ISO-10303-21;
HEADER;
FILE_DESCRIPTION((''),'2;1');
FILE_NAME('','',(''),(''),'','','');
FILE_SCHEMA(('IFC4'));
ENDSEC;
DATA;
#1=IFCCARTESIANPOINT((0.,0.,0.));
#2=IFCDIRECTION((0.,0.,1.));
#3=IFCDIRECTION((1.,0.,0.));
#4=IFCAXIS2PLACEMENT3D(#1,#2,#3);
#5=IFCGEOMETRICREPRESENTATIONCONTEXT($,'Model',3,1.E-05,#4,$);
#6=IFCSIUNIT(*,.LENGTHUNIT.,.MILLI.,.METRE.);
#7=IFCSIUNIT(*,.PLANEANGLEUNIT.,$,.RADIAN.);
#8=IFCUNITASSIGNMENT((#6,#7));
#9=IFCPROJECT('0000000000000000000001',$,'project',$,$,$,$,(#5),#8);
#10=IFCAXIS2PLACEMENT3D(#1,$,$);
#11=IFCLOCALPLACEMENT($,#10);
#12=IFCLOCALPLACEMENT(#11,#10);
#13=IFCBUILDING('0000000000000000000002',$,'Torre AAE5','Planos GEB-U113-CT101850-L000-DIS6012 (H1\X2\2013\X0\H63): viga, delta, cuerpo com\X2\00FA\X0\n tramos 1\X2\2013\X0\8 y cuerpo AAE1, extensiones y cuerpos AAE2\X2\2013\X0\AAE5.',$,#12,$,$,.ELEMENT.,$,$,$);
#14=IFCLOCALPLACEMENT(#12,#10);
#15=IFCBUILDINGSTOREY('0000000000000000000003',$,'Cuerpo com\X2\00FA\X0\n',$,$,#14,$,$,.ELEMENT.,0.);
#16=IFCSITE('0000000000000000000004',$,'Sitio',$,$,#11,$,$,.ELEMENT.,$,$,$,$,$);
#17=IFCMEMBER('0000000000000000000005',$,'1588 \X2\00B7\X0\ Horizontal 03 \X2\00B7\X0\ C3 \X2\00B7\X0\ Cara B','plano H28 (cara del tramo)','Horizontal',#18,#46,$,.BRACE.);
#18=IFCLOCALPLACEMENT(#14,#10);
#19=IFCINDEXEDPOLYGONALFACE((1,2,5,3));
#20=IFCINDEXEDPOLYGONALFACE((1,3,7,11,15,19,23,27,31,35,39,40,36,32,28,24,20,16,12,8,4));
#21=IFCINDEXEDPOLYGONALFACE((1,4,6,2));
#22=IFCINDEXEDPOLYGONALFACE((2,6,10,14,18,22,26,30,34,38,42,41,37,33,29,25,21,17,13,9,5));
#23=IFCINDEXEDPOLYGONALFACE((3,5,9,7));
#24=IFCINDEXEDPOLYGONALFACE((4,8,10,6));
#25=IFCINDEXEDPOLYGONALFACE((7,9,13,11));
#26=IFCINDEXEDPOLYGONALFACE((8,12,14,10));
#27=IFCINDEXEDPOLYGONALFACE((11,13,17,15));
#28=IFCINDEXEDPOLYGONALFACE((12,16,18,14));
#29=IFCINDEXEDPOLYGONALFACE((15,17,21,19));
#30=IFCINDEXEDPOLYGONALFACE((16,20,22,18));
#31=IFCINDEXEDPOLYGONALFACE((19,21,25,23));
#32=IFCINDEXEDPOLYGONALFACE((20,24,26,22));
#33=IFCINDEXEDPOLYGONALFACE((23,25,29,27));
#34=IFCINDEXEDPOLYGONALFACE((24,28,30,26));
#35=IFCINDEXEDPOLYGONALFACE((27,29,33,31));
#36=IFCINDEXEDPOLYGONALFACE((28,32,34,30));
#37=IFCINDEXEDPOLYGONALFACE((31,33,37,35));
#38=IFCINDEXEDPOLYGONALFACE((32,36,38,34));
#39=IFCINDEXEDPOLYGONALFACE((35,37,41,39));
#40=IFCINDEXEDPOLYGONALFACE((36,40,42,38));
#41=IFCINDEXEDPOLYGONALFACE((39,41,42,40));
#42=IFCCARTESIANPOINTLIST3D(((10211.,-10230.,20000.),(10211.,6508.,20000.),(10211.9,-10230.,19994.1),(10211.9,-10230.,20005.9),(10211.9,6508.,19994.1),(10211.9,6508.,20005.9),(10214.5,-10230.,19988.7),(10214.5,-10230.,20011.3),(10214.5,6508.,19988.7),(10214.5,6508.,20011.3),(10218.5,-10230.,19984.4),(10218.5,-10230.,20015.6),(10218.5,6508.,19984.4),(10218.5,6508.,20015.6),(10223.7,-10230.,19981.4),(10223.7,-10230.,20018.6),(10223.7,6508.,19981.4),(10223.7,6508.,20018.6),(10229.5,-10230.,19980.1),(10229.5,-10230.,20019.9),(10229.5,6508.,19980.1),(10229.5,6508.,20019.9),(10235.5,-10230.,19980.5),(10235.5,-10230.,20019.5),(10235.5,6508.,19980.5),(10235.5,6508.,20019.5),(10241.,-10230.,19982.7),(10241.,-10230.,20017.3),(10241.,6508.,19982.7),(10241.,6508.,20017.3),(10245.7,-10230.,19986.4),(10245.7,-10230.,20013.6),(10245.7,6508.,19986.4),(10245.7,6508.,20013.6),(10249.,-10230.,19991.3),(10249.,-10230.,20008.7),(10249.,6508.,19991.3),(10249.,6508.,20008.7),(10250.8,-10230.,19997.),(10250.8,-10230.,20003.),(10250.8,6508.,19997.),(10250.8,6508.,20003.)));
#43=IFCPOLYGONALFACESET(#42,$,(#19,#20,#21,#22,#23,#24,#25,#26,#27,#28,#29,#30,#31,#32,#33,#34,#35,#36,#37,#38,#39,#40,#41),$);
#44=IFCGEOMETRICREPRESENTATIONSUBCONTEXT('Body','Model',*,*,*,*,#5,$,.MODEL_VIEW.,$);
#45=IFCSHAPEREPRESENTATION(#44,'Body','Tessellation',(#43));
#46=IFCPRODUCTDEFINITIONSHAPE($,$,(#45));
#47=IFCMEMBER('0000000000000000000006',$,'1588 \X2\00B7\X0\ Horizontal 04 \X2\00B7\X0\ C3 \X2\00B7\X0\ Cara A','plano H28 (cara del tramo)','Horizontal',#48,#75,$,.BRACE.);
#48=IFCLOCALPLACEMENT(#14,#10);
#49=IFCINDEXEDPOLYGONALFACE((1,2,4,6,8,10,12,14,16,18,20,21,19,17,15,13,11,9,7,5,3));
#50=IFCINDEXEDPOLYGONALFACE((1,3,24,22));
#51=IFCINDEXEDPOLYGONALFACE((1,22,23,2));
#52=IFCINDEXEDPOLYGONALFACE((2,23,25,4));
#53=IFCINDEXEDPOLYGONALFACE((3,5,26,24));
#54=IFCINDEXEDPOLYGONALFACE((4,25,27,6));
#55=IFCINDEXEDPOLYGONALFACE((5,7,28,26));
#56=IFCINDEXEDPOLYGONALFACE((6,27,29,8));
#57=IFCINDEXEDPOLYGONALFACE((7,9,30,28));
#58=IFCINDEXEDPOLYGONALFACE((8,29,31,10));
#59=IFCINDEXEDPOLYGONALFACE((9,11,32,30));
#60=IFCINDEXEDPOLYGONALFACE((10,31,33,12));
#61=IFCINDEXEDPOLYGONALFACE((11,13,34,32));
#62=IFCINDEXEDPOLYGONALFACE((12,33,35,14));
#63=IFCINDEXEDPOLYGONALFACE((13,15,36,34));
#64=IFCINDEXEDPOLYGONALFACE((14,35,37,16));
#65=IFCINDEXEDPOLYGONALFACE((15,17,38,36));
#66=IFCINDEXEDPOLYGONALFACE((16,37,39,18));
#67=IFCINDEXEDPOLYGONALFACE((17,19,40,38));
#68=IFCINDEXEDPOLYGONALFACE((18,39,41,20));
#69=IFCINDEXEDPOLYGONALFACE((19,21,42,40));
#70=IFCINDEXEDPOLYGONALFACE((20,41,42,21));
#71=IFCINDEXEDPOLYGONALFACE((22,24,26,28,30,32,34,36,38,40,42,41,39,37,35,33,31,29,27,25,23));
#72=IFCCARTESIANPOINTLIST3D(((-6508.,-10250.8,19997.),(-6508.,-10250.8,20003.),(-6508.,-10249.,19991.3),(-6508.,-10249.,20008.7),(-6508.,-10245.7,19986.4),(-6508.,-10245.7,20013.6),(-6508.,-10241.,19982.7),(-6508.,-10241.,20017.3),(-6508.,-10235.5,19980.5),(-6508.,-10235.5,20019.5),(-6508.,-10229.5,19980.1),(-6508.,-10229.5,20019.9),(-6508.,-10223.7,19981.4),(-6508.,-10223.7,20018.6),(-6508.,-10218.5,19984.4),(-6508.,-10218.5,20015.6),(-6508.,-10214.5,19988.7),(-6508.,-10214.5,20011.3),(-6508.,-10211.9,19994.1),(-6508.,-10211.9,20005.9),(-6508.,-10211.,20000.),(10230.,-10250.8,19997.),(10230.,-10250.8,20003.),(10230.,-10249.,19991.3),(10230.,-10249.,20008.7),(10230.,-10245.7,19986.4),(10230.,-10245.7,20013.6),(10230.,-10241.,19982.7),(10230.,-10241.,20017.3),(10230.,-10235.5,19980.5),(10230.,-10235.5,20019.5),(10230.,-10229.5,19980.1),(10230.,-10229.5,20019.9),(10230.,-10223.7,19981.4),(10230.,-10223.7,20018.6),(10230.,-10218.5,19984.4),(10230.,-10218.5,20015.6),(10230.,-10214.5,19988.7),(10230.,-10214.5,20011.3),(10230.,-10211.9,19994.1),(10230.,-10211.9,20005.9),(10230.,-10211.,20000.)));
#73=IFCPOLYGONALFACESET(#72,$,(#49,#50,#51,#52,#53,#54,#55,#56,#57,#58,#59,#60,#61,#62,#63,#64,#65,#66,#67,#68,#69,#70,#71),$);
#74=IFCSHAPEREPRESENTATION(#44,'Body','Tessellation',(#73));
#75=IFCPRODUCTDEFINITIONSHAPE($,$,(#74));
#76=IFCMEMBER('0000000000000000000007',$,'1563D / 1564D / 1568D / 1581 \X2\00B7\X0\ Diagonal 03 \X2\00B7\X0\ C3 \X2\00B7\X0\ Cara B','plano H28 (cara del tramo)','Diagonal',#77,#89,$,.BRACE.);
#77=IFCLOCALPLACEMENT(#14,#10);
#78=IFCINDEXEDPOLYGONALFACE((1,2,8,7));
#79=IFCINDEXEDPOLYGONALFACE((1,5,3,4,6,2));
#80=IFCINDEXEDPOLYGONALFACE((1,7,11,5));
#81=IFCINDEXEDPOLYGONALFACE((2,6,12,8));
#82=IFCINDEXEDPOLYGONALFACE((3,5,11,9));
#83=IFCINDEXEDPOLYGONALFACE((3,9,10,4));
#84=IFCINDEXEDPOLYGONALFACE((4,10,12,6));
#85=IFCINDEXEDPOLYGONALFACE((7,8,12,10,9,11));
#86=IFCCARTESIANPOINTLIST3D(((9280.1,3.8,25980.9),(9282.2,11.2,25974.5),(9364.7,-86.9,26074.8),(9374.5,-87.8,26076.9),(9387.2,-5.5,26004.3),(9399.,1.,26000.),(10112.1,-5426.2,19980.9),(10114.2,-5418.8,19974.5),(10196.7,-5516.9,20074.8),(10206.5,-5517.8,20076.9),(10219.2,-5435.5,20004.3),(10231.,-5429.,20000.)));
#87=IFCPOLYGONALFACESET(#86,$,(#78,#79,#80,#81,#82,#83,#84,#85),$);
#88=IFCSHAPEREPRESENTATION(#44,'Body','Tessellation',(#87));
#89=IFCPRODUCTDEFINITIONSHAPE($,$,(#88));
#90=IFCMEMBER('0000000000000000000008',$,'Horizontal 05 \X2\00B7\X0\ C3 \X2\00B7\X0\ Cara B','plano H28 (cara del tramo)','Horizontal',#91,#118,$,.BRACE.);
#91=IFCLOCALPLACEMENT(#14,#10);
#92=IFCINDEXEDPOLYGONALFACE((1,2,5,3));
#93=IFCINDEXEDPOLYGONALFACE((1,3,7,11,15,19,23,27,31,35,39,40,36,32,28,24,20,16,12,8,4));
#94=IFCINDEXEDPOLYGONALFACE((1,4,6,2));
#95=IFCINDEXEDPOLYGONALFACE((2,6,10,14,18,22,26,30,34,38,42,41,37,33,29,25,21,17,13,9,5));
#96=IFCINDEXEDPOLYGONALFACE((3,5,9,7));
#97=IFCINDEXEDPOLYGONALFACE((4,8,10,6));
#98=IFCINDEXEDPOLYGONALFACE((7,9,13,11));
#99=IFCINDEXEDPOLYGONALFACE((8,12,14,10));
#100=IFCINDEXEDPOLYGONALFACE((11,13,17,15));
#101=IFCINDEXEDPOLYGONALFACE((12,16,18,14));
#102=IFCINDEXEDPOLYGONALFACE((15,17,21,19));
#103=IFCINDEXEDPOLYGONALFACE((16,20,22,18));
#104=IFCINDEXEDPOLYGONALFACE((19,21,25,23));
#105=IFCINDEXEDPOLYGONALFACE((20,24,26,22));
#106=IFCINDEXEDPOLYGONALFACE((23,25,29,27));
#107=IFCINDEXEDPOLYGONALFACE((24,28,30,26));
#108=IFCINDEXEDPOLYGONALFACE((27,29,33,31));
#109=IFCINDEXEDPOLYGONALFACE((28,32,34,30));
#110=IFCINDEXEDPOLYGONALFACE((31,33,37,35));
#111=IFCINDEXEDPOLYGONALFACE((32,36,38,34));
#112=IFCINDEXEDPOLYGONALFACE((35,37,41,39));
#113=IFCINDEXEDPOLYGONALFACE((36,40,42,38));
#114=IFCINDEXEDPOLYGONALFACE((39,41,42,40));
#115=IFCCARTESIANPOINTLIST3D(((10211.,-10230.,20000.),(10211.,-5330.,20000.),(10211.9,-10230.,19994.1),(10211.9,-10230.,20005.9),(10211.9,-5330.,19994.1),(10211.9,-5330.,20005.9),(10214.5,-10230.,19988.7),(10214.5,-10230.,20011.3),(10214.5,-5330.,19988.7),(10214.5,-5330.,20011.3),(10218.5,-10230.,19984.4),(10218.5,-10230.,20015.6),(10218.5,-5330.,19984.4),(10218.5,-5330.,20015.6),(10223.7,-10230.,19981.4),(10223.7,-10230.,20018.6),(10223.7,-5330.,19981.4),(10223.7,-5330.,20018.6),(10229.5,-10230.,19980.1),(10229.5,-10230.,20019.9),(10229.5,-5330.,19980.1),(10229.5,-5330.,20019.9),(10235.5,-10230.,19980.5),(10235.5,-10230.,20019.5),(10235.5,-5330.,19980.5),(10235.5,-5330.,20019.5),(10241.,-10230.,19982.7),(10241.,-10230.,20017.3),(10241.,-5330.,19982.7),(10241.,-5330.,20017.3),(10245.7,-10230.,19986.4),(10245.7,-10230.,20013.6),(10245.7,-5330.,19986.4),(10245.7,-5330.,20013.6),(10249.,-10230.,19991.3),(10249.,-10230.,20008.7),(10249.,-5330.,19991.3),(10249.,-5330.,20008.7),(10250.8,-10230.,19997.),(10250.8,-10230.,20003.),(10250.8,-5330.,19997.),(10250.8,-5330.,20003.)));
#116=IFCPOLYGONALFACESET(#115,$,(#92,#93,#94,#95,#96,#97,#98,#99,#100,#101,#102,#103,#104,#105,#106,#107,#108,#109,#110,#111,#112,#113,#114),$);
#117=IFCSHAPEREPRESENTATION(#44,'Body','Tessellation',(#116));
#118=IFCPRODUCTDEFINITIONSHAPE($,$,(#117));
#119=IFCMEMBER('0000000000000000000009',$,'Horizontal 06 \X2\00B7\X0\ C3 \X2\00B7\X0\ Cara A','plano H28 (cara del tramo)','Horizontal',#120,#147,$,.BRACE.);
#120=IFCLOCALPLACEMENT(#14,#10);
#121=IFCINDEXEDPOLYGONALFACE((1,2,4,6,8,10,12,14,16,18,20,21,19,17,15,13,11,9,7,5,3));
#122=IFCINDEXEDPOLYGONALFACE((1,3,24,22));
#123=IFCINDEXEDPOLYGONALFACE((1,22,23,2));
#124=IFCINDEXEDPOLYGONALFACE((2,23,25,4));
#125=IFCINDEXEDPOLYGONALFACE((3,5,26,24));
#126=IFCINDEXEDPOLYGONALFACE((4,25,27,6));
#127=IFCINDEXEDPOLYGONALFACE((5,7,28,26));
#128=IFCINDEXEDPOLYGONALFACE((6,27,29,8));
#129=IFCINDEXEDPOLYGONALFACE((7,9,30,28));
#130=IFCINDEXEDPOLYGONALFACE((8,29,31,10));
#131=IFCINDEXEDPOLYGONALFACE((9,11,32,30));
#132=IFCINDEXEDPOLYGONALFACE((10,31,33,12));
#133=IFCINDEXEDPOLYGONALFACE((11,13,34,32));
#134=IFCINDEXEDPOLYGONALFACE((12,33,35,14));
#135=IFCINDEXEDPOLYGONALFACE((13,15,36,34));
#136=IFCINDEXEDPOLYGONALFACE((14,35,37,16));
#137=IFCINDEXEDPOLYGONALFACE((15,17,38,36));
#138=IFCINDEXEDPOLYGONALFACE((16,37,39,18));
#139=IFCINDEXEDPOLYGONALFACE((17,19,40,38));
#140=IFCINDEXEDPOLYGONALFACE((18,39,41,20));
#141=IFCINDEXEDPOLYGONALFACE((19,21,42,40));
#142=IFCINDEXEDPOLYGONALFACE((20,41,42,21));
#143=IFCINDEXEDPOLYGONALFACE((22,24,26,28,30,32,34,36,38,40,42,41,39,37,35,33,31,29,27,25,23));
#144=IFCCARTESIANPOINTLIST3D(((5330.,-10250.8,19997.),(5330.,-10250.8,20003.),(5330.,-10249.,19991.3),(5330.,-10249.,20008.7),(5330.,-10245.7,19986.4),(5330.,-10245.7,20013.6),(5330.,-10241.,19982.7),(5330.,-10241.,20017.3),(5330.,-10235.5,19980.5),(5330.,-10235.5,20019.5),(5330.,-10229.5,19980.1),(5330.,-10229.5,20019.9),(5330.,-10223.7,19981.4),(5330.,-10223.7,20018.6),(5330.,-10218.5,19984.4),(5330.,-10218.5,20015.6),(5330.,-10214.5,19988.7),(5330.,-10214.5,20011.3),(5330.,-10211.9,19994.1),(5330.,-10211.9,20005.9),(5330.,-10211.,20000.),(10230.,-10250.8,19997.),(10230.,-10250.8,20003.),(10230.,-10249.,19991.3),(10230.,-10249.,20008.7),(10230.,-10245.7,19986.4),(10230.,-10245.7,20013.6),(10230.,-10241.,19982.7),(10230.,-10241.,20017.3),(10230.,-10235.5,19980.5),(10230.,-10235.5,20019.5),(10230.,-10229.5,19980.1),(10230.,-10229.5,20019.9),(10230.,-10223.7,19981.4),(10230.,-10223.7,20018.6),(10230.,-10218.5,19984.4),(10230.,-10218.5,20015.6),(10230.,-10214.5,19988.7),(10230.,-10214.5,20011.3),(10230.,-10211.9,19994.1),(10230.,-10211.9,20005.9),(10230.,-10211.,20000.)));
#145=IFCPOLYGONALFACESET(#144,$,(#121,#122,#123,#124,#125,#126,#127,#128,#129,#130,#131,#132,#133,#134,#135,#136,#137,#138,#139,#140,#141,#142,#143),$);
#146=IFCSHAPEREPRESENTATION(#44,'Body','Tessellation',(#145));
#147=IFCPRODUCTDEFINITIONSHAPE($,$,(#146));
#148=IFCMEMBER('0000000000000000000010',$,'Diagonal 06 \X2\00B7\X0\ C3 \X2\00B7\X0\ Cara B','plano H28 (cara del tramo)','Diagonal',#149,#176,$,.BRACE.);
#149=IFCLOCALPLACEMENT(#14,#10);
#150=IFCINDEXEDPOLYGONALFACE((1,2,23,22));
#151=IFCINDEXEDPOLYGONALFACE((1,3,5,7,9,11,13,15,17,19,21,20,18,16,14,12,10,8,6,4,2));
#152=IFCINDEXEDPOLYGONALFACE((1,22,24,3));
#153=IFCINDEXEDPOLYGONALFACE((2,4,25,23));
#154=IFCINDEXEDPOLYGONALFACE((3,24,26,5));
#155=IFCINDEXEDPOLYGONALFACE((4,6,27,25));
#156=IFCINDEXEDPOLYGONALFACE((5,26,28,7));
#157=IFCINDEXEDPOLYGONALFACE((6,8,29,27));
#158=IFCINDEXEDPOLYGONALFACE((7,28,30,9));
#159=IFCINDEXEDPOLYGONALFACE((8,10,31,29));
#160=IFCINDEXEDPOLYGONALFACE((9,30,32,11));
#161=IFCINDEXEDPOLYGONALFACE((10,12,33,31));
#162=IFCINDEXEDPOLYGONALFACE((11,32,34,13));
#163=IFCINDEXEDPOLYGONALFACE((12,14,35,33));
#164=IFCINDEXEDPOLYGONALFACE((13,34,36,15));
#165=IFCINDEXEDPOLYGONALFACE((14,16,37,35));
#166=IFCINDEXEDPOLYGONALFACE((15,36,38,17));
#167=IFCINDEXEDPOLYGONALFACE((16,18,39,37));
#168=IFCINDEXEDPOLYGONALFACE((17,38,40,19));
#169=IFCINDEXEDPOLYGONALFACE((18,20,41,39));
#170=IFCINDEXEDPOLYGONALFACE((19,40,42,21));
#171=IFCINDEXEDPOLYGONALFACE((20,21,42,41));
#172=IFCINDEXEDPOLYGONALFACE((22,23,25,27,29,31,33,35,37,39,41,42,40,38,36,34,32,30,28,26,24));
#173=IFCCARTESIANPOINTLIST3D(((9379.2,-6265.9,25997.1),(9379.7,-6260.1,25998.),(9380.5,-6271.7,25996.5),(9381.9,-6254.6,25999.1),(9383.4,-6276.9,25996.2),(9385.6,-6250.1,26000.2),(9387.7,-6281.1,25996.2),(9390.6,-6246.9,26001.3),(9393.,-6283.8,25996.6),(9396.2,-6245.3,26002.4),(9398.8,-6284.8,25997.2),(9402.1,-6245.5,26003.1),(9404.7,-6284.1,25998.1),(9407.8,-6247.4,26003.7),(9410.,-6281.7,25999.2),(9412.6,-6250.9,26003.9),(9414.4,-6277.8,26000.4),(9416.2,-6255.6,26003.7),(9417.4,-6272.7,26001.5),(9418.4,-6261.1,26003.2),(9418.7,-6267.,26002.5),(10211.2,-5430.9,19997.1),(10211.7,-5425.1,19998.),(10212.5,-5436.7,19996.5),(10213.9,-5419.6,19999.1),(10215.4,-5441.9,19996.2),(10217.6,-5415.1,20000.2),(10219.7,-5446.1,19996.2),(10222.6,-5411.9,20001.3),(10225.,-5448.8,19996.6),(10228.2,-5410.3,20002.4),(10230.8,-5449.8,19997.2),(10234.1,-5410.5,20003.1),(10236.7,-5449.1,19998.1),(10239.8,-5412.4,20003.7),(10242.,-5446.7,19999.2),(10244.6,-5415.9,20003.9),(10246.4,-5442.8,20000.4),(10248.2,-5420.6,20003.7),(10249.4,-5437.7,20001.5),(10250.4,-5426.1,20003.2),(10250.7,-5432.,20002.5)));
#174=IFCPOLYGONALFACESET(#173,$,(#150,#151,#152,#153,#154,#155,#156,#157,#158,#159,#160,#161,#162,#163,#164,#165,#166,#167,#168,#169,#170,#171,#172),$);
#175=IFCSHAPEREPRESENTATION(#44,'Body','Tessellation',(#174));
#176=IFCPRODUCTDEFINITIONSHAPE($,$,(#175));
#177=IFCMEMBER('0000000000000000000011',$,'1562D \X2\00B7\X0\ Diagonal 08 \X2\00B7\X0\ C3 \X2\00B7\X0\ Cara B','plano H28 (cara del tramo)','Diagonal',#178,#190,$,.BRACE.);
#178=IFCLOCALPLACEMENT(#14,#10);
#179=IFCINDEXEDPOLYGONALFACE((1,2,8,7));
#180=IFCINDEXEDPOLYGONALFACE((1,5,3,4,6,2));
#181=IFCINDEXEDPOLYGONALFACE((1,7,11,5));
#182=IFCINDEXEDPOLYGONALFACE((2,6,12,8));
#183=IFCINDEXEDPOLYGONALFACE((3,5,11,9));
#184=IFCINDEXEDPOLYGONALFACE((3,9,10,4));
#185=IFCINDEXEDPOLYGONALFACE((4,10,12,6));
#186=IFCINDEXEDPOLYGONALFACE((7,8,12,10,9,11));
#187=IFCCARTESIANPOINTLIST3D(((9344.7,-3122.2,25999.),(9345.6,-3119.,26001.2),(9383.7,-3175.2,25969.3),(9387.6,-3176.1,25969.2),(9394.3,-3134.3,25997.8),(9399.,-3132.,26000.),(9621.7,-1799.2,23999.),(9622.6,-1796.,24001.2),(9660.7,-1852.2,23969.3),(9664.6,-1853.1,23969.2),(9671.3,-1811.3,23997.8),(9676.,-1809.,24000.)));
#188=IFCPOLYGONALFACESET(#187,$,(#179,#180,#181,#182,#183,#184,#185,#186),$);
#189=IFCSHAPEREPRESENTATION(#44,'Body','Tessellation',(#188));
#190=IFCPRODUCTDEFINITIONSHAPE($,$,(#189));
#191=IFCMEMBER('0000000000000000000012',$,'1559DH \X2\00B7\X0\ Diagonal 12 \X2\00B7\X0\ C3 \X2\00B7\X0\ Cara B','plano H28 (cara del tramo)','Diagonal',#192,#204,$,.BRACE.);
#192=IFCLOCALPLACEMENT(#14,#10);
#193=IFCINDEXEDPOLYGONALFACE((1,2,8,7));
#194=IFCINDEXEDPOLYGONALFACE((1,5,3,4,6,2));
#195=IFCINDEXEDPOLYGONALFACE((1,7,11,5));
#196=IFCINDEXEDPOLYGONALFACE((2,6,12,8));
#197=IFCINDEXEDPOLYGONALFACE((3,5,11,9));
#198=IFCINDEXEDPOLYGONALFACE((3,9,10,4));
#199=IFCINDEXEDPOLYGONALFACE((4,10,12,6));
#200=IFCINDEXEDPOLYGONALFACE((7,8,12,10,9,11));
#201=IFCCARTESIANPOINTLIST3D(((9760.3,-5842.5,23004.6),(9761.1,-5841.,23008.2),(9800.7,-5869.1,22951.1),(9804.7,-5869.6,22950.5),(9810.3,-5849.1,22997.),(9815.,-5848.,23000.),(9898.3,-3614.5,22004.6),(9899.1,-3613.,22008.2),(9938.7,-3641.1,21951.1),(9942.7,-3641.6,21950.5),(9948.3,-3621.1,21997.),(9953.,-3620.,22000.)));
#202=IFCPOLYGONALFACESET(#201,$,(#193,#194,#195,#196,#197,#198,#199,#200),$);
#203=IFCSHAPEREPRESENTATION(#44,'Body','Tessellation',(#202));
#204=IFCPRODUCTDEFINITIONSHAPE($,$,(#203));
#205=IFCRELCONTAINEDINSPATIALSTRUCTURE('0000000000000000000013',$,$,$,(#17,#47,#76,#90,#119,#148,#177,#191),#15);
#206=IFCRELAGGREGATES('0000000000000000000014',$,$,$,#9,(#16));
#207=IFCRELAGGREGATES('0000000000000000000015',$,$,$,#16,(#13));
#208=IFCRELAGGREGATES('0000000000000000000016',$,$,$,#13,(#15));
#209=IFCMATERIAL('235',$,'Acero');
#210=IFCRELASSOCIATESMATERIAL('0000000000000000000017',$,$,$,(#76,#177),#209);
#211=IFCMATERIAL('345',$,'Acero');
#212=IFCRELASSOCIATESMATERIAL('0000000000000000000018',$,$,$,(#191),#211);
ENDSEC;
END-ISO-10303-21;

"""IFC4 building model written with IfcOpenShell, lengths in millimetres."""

from ifc_helpers import new_model, si_unit, frame, frame_2d, origin, origin_with_axes, place, context, subcontext, project, spatial, circle, l_section, extrude, material, element, save


model = new_model("IFC4")

# Units and contexts
model_context = context("Model", 3, precision=1e-05, world=origin_with_axes())
body_context = subcontext(model_context, "Body", "Model", "MODEL_VIEW")
ifc_project = project(units=[si_unit("LENGTHUNIT", "METRE", prefix="MILLI"), si_unit("PLANEANGLEUNIT", "RADIAN")], contexts=[model_context])

# Site, building, storey
site_placement = place(None, origin())
site = spatial("IfcSite", under=ifc_project, at=site_placement, Name="Sitio", CompositionType="ELEMENT")
building_placement = place(site_placement, origin())
building = spatial("IfcBuilding", under=site, at=building_placement, Name="Torre AAE5", Description="Planos GEB-U113-CT101850-L000-DIS6012 (H1–H63): viga, delta, cuerpo común tramos 1–8 y cuerpo AAE1, extensiones y cuerpos AAE2–AAE5.", CompositionType="ELEMENT")
storey_placement = place(building_placement, origin())
storey = spatial("IfcBuildingStorey", under=building, at=storey_placement, Name="Cuerpo común", CompositionType="ELEMENT", Elevation=0.0)

# Members
for number, where, z_axis, x_axis, name in (
    (1, (10231.0, -10230.0, 20000.0), (0.0, 1.0, 0.0), (-1.0, 0.0, 0.0), "1588 · Horizontal 03 · C3 · Cara B"),
    (2, (10230.0, -10231.0, 20000.0), (-1.0, 0.0, 0.0), (0.0, 1.0, 0.0), "1588 · Horizontal 04 · C3 · Cara A"),
):
    element("IfcMember", number, at=place(storey_placement, frame(where, z_axis=z_axis, x_axis=x_axis)), inside=storey, Name=name, Description="plano H28 (cara del tramo)", ObjectType="Horizontal", PredefinedType="BRACE", context=body_context, shape_type="SweptSolid", body=[
        extrude(circle(Radius=20.0), None, (0.0, 0.0, 1.0), 16738.0),
    ])
ifc_material_1 = material(Name="235", Category="Acero")
member_1_placement = place(storey_placement, frame((10231.0, -5429.0, 20000.0), z_axis=(-0.102275, 0.667492, 0.73756), x_axis=(-0.9735, 0.085296, -0.212185)))
element("IfcMember", 3, at=member_1_placement, inside=storey, material=ifc_material_1, Name="1563D / 1564D / 1568D / 1581 · Diagonal 03 · C3 · Cara B", Description="plano H28 (cara del tramo)", ObjectType="Diagonal", PredefinedType="BRACE", context=body_context, shape_type="SweptSolid", body=[
    extrude(l_section(Depth=120.0, Width=120.0, Thickness=10.0, at=frame_2d((60.0, 60.0))), None, (0.0, 0.0, 1.0), 8134.9),
])
for number, where, z_axis, x_axis, name in (
    (4, (10231.0, -10230.0, 20000.0), (0.0, 1.0, 0.0), (-1.0, 0.0, 0.0), "Horizontal 05 · C3 · Cara B"),
    (5, (10230.0, -10231.0, 20000.0), (-1.0, 0.0, 0.0), (0.0, 1.0, 0.0), "Horizontal 06 · C3 · Cara A"),
):
    element("IfcMember", number, at=place(storey_placement, frame(where, z_axis=z_axis, x_axis=x_axis)), inside=storey, Name=name, Description="plano H28 (cara del tramo)", ObjectType="Horizontal", PredefinedType="BRACE", context=body_context, shape_type="SweptSolid", body=[
        extrude(circle(Radius=20.0), None, (0.0, 0.0, 1.0), 4900.0),
    ])
member_2_placement = place(storey_placement, frame((10231.0, -5430.0, 20000.0), z_axis=(-0.136066, -0.136556, 0.981243), x_axis=(-0.85364, 0.518814, -0.04617)))
element("IfcMember", 6, at=member_2_placement, inside=storey, Name="Diagonal 06 · C3 · Cara B", Description="plano H28 (cara del tramo)", ObjectType="Diagonal", PredefinedType="BRACE", context=body_context, shape_type="SweptSolid", body=[
    extrude(circle(Radius=20.0), None, (0.0, 0.0, 1.0), 6114.7),
])
member_3_placement = place(storey_placement, frame((9676.0, -1809.0, 24000.0), z_axis=(-0.114751, -0.548069, 0.828524), x_axis=(-0.971411, 0.236397, 0.021836)))
element("IfcMember", 7, at=member_3_placement, inside=storey, material=ifc_material_1, Name="1562D · Diagonal 08 · C3 · Cara B", Description="plano H28 (cara del tramo)", ObjectType="Diagonal", PredefinedType="BRACE", context=body_context, shape_type="SweptSolid", body=[
    extrude(l_section(Depth=55.0, Width=55.0, Thickness=4.0, at=frame_2d((27.5, 27.5))), None, (0.0, 0.0, 1.0), 2413.9),
])
ifc_material_2 = material(Name="345", Category="Acero")
member_4_placement = place(storey_placement, frame((9953.0, -3620.0, 22000.0), z_axis=(-0.056418, -0.910866, 0.408827), x_axis=(-0.980552, 0.127645, 0.149077)))
element("IfcMember", 8, at=member_4_placement, inside=storey, material=ifc_material_2, Name="1559DH · Diagonal 12 · C3 · Cara B", Description="plano H28 (cara del tramo)", ObjectType="Diagonal", PredefinedType="BRACE", context=body_context, shape_type="SweptSolid", body=[
    extrude(l_section(Depth=55.0, Width=55.0, Thickness=4.0, at=frame_2d((27.5, 27.5))), None, (0.0, 0.0, 1.0), 2446.0),
])

save(model, "model.ifc")
